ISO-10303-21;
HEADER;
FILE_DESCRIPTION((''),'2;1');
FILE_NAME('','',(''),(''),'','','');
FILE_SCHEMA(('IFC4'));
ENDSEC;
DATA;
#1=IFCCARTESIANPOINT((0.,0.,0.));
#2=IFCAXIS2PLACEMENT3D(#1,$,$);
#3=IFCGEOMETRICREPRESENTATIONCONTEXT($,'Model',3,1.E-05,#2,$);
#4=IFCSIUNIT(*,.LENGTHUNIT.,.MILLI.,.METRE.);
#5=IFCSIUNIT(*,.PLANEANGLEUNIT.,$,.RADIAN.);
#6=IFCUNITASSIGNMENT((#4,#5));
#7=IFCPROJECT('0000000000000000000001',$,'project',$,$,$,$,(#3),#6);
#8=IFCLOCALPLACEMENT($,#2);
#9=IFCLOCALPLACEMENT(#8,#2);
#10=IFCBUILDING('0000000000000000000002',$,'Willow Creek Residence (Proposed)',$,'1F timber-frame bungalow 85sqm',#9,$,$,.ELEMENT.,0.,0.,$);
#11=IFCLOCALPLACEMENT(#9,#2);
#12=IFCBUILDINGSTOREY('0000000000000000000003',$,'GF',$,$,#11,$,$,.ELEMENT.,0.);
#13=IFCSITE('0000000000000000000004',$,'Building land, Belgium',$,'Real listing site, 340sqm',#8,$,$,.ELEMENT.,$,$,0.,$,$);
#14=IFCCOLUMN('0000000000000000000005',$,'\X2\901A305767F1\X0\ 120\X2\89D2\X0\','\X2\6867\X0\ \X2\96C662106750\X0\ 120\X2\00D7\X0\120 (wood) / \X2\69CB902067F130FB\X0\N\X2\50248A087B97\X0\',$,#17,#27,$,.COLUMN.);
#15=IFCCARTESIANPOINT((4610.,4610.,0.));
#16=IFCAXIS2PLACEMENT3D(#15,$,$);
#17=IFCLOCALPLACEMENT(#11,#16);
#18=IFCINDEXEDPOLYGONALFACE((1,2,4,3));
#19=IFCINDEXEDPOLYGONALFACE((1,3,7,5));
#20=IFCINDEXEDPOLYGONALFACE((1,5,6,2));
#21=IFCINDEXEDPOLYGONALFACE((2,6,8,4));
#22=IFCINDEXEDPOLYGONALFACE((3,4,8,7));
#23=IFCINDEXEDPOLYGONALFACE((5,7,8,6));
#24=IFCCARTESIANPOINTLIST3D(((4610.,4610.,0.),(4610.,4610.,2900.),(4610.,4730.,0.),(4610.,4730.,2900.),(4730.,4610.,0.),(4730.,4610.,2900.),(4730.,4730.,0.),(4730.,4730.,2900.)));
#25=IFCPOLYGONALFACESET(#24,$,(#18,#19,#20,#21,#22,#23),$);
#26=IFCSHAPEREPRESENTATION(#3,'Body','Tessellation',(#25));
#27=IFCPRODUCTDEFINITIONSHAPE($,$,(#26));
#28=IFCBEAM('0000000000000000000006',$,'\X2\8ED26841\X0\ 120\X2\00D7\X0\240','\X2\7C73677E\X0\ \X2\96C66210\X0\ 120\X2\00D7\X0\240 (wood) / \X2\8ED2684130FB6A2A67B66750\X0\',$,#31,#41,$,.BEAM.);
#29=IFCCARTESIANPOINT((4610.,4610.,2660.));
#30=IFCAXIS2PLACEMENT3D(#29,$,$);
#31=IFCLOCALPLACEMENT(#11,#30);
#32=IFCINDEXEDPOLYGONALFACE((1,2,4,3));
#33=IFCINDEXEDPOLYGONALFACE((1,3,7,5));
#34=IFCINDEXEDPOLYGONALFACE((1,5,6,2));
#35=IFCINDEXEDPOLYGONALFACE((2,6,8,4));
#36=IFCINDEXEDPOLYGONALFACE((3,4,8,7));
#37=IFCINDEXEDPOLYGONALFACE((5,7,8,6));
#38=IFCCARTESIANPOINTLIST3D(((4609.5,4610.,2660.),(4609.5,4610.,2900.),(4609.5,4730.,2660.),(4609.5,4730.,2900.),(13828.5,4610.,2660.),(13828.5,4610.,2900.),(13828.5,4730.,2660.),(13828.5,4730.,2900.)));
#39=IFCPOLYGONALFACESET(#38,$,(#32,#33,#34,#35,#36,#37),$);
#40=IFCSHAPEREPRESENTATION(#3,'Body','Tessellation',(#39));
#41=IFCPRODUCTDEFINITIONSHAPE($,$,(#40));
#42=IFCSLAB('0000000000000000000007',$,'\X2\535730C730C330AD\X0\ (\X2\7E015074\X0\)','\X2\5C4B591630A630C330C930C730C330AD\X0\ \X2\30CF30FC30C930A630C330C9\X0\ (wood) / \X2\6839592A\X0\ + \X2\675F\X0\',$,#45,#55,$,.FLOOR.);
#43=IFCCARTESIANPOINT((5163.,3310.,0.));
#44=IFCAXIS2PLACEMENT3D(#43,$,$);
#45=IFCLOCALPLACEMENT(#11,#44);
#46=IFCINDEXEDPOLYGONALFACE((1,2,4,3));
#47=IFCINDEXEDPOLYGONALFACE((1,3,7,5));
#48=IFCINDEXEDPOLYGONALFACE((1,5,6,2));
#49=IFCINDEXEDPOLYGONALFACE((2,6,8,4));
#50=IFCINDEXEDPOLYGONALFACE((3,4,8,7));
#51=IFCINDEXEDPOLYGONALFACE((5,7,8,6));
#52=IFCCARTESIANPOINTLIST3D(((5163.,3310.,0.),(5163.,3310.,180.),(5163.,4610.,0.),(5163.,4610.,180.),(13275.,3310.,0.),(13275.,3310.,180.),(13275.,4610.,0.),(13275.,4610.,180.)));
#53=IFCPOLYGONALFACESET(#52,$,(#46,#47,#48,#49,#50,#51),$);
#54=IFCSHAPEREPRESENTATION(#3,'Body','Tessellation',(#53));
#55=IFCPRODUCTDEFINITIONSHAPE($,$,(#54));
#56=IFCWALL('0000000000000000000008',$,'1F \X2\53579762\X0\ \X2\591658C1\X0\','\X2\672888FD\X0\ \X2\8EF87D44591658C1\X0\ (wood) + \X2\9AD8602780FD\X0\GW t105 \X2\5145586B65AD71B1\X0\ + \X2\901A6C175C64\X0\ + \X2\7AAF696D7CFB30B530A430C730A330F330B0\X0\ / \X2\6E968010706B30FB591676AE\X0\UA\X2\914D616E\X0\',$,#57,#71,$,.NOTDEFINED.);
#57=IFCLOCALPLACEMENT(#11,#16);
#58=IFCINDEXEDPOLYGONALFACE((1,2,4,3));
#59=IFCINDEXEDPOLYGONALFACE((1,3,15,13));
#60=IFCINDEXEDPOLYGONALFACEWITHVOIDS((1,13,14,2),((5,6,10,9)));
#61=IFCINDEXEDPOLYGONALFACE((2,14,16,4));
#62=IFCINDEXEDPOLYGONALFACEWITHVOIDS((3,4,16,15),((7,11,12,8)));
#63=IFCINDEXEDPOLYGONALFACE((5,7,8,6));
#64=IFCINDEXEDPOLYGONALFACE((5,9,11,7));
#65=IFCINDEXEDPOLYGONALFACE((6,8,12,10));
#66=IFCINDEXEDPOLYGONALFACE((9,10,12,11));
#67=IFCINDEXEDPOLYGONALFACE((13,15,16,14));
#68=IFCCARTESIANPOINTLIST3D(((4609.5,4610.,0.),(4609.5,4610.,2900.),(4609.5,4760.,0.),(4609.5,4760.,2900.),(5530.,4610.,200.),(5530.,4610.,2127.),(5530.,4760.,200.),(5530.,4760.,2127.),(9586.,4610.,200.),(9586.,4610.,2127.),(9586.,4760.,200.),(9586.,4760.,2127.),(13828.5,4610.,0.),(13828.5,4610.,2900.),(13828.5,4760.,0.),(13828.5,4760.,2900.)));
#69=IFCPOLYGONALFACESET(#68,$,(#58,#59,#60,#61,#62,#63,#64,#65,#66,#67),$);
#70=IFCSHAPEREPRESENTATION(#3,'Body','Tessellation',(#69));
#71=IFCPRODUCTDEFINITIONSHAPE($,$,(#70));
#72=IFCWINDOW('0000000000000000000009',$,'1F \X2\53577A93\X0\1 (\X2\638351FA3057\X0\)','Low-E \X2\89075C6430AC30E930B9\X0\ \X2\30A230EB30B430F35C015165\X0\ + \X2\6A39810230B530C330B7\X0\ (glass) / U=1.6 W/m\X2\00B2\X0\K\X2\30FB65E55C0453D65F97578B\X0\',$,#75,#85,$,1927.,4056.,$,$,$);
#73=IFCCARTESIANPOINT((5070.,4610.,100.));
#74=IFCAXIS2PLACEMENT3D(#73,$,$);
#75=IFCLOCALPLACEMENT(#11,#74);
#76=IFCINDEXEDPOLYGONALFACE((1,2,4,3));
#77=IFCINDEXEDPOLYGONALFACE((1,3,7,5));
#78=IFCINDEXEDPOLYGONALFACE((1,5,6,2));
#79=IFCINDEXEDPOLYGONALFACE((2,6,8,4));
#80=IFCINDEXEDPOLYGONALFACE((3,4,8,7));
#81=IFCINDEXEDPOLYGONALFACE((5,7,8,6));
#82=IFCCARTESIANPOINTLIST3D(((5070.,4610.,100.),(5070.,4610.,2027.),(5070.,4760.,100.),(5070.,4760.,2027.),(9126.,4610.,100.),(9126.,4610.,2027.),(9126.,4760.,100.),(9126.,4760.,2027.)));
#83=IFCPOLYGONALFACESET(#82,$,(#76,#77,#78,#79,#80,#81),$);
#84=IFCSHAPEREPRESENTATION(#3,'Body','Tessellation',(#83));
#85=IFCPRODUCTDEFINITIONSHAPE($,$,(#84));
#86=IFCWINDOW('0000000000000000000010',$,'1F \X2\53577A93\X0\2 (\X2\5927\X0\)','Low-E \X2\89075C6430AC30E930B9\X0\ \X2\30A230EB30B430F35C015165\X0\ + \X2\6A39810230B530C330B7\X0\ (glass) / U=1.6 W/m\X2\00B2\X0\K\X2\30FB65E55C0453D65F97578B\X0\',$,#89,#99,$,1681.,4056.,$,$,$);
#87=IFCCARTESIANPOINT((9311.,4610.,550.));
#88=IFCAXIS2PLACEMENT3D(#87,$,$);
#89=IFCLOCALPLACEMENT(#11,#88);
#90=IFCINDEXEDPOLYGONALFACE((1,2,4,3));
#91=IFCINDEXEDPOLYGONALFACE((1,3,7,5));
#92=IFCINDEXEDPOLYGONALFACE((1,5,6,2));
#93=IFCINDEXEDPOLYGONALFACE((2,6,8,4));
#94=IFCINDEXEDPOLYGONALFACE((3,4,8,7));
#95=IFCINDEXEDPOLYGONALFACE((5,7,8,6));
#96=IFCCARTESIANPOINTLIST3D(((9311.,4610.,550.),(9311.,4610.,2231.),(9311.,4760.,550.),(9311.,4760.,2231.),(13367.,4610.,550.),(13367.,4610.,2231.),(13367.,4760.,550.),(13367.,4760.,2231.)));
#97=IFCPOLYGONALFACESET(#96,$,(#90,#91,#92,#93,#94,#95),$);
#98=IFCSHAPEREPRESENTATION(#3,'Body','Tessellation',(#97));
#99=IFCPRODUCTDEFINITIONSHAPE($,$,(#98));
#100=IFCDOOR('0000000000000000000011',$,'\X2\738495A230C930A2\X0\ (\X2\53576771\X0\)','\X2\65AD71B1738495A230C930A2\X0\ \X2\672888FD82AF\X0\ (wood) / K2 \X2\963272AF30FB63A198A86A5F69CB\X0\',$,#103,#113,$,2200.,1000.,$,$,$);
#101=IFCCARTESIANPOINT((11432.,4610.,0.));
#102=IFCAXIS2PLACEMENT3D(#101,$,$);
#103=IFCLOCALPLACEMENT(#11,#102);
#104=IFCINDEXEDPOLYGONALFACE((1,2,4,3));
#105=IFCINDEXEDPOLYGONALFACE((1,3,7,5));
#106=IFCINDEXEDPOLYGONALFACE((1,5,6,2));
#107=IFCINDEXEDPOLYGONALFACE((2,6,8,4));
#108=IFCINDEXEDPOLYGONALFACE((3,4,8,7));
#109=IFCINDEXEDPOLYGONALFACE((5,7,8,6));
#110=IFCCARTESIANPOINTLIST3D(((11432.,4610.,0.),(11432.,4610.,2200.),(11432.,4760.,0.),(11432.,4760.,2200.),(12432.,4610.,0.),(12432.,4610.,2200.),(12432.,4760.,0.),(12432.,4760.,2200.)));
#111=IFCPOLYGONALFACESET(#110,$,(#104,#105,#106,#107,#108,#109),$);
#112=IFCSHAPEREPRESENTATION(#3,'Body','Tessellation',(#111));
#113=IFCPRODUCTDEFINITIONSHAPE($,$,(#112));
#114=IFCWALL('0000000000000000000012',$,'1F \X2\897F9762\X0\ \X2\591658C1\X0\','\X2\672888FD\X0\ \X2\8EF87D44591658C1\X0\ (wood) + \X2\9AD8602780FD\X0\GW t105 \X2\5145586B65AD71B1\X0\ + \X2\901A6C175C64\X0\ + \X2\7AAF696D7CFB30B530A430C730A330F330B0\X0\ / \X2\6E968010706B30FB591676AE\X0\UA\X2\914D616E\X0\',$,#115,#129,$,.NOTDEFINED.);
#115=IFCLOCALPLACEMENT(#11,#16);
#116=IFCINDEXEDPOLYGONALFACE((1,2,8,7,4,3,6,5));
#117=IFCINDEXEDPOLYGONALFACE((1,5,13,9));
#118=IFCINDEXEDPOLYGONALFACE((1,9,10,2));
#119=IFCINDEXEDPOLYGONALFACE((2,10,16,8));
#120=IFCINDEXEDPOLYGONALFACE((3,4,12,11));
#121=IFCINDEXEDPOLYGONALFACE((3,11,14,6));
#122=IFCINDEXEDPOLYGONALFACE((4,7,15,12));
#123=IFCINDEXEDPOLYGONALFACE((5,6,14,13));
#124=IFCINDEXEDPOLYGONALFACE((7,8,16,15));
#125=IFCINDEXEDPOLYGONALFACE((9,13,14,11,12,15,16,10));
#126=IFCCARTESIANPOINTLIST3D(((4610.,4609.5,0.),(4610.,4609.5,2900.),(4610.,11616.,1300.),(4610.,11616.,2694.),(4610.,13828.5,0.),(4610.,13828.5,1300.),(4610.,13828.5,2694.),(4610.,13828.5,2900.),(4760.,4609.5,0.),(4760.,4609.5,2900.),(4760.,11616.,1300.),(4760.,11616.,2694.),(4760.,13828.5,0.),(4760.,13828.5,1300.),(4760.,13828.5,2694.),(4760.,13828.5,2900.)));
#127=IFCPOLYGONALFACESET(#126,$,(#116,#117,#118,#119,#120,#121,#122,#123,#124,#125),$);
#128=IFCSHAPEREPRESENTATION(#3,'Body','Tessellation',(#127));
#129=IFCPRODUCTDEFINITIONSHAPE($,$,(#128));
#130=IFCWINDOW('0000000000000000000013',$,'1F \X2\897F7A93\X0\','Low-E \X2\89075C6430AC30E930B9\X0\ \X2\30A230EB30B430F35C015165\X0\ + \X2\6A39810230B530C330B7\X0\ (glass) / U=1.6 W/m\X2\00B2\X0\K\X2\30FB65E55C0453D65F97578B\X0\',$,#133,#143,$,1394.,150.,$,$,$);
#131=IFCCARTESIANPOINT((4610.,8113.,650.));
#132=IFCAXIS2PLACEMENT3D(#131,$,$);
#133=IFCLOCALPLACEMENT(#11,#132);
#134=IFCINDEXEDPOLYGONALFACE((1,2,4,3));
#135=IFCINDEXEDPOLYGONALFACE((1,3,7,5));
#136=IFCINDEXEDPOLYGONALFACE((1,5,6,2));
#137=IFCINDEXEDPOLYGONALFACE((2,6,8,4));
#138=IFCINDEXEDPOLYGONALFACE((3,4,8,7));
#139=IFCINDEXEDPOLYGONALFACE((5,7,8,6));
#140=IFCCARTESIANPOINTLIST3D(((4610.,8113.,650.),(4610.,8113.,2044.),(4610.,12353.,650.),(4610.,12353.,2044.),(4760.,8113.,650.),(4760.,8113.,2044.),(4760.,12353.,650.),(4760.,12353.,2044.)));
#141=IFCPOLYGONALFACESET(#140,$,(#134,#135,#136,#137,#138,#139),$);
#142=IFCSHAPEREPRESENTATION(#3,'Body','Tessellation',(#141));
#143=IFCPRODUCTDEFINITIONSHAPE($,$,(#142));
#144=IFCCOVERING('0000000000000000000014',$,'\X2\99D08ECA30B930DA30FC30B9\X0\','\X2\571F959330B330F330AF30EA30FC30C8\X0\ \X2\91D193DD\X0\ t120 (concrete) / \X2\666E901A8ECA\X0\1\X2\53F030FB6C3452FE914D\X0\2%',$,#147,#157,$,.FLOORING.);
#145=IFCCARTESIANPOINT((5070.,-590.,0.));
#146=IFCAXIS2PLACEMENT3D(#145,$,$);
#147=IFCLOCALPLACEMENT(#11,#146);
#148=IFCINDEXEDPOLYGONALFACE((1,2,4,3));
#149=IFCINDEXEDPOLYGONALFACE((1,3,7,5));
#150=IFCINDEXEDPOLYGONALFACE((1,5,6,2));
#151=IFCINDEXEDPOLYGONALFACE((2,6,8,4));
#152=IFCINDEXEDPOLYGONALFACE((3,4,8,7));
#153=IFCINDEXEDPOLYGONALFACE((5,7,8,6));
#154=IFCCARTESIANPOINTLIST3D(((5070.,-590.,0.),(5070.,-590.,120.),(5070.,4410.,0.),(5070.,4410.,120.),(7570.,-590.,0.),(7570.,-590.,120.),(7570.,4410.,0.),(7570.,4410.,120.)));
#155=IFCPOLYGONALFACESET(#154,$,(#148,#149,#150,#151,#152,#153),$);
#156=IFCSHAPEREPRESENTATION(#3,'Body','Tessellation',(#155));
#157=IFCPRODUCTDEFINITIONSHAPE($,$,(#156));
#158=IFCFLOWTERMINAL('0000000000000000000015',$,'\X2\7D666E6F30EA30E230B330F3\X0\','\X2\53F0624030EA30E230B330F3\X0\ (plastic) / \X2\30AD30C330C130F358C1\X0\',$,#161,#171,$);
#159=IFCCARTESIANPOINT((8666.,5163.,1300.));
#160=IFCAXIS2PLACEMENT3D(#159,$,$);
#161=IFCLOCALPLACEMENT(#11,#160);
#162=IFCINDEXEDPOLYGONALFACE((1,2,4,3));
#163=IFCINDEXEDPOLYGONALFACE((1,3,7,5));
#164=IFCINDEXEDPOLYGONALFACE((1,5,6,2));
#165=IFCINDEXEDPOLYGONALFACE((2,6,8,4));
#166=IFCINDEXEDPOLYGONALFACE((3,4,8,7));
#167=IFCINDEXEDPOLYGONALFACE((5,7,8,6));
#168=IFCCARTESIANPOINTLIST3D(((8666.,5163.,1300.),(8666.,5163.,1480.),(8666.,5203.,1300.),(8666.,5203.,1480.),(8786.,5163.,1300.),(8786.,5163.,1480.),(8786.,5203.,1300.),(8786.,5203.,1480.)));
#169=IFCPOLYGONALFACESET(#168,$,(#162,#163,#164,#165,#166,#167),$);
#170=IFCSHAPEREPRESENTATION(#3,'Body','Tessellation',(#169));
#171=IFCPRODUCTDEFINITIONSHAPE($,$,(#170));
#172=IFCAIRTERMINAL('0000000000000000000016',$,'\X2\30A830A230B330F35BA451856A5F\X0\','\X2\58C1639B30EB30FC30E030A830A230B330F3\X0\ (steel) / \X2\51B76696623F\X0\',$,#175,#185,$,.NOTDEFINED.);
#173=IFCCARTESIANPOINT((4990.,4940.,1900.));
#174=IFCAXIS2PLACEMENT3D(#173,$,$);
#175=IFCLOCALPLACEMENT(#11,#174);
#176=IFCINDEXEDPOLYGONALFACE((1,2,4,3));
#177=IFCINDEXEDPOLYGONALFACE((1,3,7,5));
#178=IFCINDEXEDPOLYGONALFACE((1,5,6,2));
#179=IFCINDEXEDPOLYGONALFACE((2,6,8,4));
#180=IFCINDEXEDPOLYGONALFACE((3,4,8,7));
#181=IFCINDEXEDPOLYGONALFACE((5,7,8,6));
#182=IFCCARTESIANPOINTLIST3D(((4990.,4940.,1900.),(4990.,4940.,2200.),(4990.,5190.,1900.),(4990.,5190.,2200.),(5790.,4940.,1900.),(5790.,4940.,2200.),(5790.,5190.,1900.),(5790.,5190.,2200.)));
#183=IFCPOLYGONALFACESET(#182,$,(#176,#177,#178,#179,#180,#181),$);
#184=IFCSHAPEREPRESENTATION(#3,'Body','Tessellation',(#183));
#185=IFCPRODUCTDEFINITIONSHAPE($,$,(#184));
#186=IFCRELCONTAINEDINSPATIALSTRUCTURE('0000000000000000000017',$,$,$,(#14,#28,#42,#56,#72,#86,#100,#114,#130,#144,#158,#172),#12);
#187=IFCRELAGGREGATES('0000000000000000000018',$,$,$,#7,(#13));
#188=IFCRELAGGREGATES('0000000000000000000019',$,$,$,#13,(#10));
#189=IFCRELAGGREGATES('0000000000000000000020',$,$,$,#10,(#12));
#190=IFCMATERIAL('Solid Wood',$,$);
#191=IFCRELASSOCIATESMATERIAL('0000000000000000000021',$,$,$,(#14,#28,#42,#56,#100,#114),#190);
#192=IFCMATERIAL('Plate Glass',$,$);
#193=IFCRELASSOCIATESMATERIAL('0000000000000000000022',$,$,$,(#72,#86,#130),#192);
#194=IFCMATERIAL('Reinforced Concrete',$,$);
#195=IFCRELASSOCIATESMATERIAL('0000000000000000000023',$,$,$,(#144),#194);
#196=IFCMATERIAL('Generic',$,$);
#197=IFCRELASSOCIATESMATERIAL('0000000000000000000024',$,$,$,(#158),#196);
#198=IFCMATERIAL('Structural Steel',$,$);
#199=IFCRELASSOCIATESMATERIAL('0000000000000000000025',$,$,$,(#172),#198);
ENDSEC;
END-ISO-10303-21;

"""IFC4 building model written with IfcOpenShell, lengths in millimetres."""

from ifc_helpers import new_model, si_unit, frame, frame_2d, origin, place, context, project, spatial, rectangle, extrude, material, element, fill, save


model = new_model("IFC4")

# Units and contexts
model_context = context("Model", 3, precision=1e-05, world=origin())
ifc_project = project(units=[si_unit("LENGTHUNIT", "METRE", prefix="MILLI"), si_unit("PLANEANGLEUNIT", "RADIAN")], contexts=[model_context])

# Site, building, storey
site_placement = place(None, origin())
site = spatial("IfcSite", under=ifc_project, at=site_placement, Name="Building land, Belgium", ObjectType="Real listing site, 340sqm", CompositionType="ELEMENT", RefElevation=0.0)
building_placement = place(site_placement, origin())
building = spatial("IfcBuilding", under=site, at=building_placement, Name="Willow Creek Residence (Proposed)", ObjectType="1F timber-frame bungalow 85sqm", CompositionType="ELEMENT", ElevationOfRefHeight=0.0, ElevationOfTerrain=0.0)
storey_placement = place(building_placement, origin())
storey = spatial("IfcBuildingStorey", under=building, at=storey_placement, Name="GF", CompositionType="ELEMENT", Elevation=0.0)

# Column
ifc_material_1 = material(Name="Solid Wood")
column_1_placement = place(storey_placement, frame((4610.0, 4610.0, 0.0)))
element("IfcColumn", 1, at=column_1_placement, inside=storey, material=ifc_material_1, Name="通し柱 120角", Description="桧 集成材 120×120 (wood) / 構造柱・N値計算", PredefinedType="COLUMN", context=model_context, shape_type="SweptSolid", body=[
    extrude(rectangle(XDim=120.0, YDim=120.0, at=frame_2d((60.0, 60.0))), frame((4610.0, 4610.0, 0.0)), (0.0, 0.0, 1.0), 2900.0),
])

# Beam
beam_1_placement = place(storey_placement, frame((4610.0, 4610.0, 2660.0)))
element("IfcBeam", 2, at=beam_1_placement, inside=storey, material=ifc_material_1, Name="軒桁 120×240", Description="米松 集成 120×240 (wood) / 軒桁・横架材", PredefinedType="BEAM", context=model_context, shape_type="SweptSolid", body=[
    extrude(rectangle(XDim=9219.0, YDim=120.0, at=frame_2d((4609.0, 60.0))), frame((4610.0, 4610.0, 2660.0)), (0.0, 0.0, 1.0), 240.0),
])

# Slab
ifc_material_2 = material(Name="Reinforced Concrete")
slab_1_placement = place(storey_placement, frame((5163.0, 3310.0, 0.0)))
element("IfcSlab", 3, at=slab_1_placement, inside=storey, material=ifc_material_1, Name="南デッキ (縁側)", Description="屋外ウッドデッキ ハードウッド (wood) / 根太 + 束", PredefinedType="FLOOR", context=model_context, shape_type="SweptSolid", body=[
    extrude(rectangle(XDim=8112.0, YDim=1300.0, at=frame_2d((4056.0, 650.0))), frame((5163.0, 3310.0, 0.0)), (0.0, 0.0, 1.0), 180.0),
])

# Wall, openings, windows, door
wall_1_placement = place(storey_placement, frame((4610.0, 4610.0, 0.0)))
wall_1 = element("IfcWall", 4, at=wall_1_placement, inside=storey, material=ifc_material_1, Name="1F 南面 外壁", Description="木製 軸組外壁 (wood) + 高性能GW t105 充填断熱 + 通気層 + 窯業系サイディング / 準耐火・外皮UA配慮", PredefinedType="NOTDEFINED", context=model_context, shape_type="SweptSolid", body=[
    extrude(rectangle(XDim=9219.0, YDim=150.0, at=frame_2d((4609.0, 75.0))), frame((4610.0, 4610.0, 0.0)), (0.0, 0.0, 1.0), 2900.0),
])
opening_1_placement = place(storey_placement, frame((5070.0, 4610.0, 100.0)))
opening_1 = element("IfcOpeningElement", 5, at=opening_1_placement, cuts=wall_1, PredefinedType="NOTDEFINED", context=model_context, shape_type="SweptSolid", body=[
    extrude(rectangle(XDim=4056.0, YDim=150.0, at=frame_2d((2028.0, 75.0))), frame((5070.0, 4610.0, 100.0)), (0.0, 0.0, 1.0), 1927.0),
])
opening_2_placement = place(storey_placement, frame((9311.0, 4610.0, 550.0)))
opening_2 = element("IfcOpeningElement", 6, at=opening_2_placement, cuts=wall_1, PredefinedType="NOTDEFINED", context=model_context, shape_type="SweptSolid", body=[
    extrude(rectangle(XDim=4056.0, YDim=150.0, at=frame_2d((2028.0, 75.0))), frame((9311.0, 4610.0, 550.0)), (0.0, 0.0, 1.0), 1681.0),
])
opening_3_placement = place(storey_placement, frame((11432.0, 4610.0, 0.0)))
opening_3 = element("IfcOpeningElement", 7, at=opening_3_placement, cuts=wall_1, PredefinedType="NOTDEFINED", context=model_context, shape_type="SweptSolid", body=[
    extrude(rectangle(XDim=1000.0, YDim=150.0, at=frame_2d((500.0, 75.0))), frame((11432.0, 4610.0, 0.0)), (0.0, 0.0, 1.0), 2200.0),
])
ifc_material_3 = material(Name="Plate Glass")
window_1_placement = place(storey_placement, frame((5070.0, 4610.0, 100.0)))
window_1 = element("IfcWindow", 8, at=window_1_placement, inside=storey, material=ifc_material_3, Name="1F 南窓1 (掃出し)", Description="Low-E 複層ガラス アルゴン封入 + 樹脂サッシ (glass) / U=1.6 W/m²K・日射取得型", OverallHeight=1927.0, OverallWidth=4056.0, context=model_context, shape_type="SweptSolid", body=[
    extrude(rectangle(XDim=4056.0, YDim=150.0, at=frame_2d((2028.0, 75.0))), frame((5070.0, 4610.0, 100.0)), (0.0, 0.0, 1.0), 1927.0),
])
fill(opening_1, window_1)
window_2_placement = place(storey_placement, frame((9311.0, 4610.0, 550.0)))
window_2 = element("IfcWindow", 9, at=window_2_placement, inside=storey, material=ifc_material_3, Name="1F 南窓2 (大)", Description="Low-E 複層ガラス アルゴン封入 + 樹脂サッシ (glass) / U=1.6 W/m²K・日射取得型", OverallHeight=1681.0, OverallWidth=4056.0, context=model_context, shape_type="SweptSolid", body=[
    extrude(rectangle(XDim=4056.0, YDim=150.0, at=frame_2d((2028.0, 75.0))), frame((9311.0, 4610.0, 550.0)), (0.0, 0.0, 1.0), 1681.0),
])
fill(opening_2, window_2)
door_placement = place(storey_placement, frame((11432.0, 4610.0, 0.0)))
door = element("IfcDoor", 10, at=door_placement, inside=storey, material=ifc_material_1, Name="玄関ドア (南東)", Description="断熱玄関ドア 木製芯 (wood) / K2 防犯・採風機構", OverallHeight=2200.0, OverallWidth=1000.0, context=model_context, shape_type="SweptSolid", body=[
    extrude(rectangle(XDim=1000.0, YDim=150.0, at=frame_2d((500.0, 75.0))), frame((11432.0, 4610.0, 0.0)), (0.0, 0.0, 1.0), 2200.0),
])
fill(opening_3, door)

# Wall, opening, window
wall_2_placement = place(storey_placement, frame((4610.0, 4610.0, 0.0)))
wall_2 = element("IfcWall", 11, at=wall_2_placement, inside=storey, material=ifc_material_1, Name="1F 西面 外壁", Description="木製 軸組外壁 (wood) + 高性能GW t105 充填断熱 + 通気層 + 窯業系サイディング / 準耐火・外皮UA配慮", PredefinedType="NOTDEFINED", context=model_context, shape_type="SweptSolid", body=[
    extrude(rectangle(XDim=150.0, YDim=9219.0, at=frame_2d((75.0, 4609.0))), frame((4610.0, 4610.0, 0.0)), (0.0, 0.0, 1.0), 2900.0),
])
opening_4_placement = place(storey_placement, frame((4610.0, 8113.0, 650.0)))
opening_4 = element("IfcOpeningElement", 12, at=opening_4_placement, cuts=wall_2, PredefinedType="NOTDEFINED", context=model_context, shape_type="SweptSolid", body=[
    extrude(rectangle(XDim=150.0, YDim=4240.0, at=frame_2d((75.0, 2120.0))), frame((4610.0, 8113.0, 650.0)), (0.0, 0.0, 1.0), 1394.0),
])
window_3_placement = place(storey_placement, frame((4610.0, 8113.0, 650.0)))
window_3 = element("IfcWindow", 13, at=window_3_placement, inside=storey, material=ifc_material_3, Name="1F 西窓", Description="Low-E 複層ガラス アルゴン封入 + 樹脂サッシ (glass) / U=1.6 W/m²K・日射取得型", OverallHeight=1394.0, OverallWidth=150.0, context=model_context, shape_type="SweptSolid", body=[
    extrude(rectangle(XDim=150.0, YDim=4240.0, at=frame_2d((75.0, 2120.0))), frame((4610.0, 8113.0, 650.0)), (0.0, 0.0, 1.0), 1394.0),
])
fill(opening_4, window_3)

# Shared definitions
ifc_material_4 = material(Name="Structural Steel")

# Covering
ifc_material_5 = material(Name="Generic")
covering_1_placement = place(storey_placement, frame((5070.0, -590.0, 0.0)))
element("IfcCovering", 14, at=covering_1_placement, inside=storey, material=ifc_material_2, Name="駐車スペース", Description="土間コンクリート 金鏝 t120 (concrete) / 普通車1台・水勾配2%", PredefinedType="FLOORING", context=model_context, shape_type="SweptSolid", body=[
    extrude(rectangle(XDim=2500.0, YDim=5000.0, at=frame_2d((1250.0, 2500.0))), frame((5070.0, -590.0, 0.0)), (0.0, 0.0, 1.0), 120.0),
])

# Flow terminal
flow_terminal_placement = place(storey_placement, frame((8666.0, 5163.0, 1300.0)))
element("IfcFlowTerminal", 15, at=flow_terminal_placement, inside=storey, material=ifc_material_5, Name="給湯リモコン", Description="台所リモコン (plastic) / キッチン壁", context=model_context, shape_type="SweptSolid", body=[
    extrude(rectangle(XDim=120.0, YDim=40.0, at=frame_2d((60.0, 20.0))), frame((8666.0, 5163.0, 1300.0)), (0.0, 0.0, 1.0), 180.0),
])

# Air terminal
air_terminal_placement = place(storey_placement, frame((4990.0, 4940.0, 1900.0)))
element("IfcAirTerminal", 16, at=air_terminal_placement, inside=storey, material=ifc_material_4, Name="エアコン室内機", Description="壁掛ルームエアコン (steel) / 冷暖房", PredefinedType="NOTDEFINED", context=model_context, shape_type="SweptSolid", body=[
    extrude(rectangle(XDim=800.0, YDim=250.0, at=frame_2d((400.0, 125.0))), frame((4990.0, 4940.0, 1900.0)), (0.0, 0.0, 1.0), 300.0),
])

save(model, "model.ifc")
